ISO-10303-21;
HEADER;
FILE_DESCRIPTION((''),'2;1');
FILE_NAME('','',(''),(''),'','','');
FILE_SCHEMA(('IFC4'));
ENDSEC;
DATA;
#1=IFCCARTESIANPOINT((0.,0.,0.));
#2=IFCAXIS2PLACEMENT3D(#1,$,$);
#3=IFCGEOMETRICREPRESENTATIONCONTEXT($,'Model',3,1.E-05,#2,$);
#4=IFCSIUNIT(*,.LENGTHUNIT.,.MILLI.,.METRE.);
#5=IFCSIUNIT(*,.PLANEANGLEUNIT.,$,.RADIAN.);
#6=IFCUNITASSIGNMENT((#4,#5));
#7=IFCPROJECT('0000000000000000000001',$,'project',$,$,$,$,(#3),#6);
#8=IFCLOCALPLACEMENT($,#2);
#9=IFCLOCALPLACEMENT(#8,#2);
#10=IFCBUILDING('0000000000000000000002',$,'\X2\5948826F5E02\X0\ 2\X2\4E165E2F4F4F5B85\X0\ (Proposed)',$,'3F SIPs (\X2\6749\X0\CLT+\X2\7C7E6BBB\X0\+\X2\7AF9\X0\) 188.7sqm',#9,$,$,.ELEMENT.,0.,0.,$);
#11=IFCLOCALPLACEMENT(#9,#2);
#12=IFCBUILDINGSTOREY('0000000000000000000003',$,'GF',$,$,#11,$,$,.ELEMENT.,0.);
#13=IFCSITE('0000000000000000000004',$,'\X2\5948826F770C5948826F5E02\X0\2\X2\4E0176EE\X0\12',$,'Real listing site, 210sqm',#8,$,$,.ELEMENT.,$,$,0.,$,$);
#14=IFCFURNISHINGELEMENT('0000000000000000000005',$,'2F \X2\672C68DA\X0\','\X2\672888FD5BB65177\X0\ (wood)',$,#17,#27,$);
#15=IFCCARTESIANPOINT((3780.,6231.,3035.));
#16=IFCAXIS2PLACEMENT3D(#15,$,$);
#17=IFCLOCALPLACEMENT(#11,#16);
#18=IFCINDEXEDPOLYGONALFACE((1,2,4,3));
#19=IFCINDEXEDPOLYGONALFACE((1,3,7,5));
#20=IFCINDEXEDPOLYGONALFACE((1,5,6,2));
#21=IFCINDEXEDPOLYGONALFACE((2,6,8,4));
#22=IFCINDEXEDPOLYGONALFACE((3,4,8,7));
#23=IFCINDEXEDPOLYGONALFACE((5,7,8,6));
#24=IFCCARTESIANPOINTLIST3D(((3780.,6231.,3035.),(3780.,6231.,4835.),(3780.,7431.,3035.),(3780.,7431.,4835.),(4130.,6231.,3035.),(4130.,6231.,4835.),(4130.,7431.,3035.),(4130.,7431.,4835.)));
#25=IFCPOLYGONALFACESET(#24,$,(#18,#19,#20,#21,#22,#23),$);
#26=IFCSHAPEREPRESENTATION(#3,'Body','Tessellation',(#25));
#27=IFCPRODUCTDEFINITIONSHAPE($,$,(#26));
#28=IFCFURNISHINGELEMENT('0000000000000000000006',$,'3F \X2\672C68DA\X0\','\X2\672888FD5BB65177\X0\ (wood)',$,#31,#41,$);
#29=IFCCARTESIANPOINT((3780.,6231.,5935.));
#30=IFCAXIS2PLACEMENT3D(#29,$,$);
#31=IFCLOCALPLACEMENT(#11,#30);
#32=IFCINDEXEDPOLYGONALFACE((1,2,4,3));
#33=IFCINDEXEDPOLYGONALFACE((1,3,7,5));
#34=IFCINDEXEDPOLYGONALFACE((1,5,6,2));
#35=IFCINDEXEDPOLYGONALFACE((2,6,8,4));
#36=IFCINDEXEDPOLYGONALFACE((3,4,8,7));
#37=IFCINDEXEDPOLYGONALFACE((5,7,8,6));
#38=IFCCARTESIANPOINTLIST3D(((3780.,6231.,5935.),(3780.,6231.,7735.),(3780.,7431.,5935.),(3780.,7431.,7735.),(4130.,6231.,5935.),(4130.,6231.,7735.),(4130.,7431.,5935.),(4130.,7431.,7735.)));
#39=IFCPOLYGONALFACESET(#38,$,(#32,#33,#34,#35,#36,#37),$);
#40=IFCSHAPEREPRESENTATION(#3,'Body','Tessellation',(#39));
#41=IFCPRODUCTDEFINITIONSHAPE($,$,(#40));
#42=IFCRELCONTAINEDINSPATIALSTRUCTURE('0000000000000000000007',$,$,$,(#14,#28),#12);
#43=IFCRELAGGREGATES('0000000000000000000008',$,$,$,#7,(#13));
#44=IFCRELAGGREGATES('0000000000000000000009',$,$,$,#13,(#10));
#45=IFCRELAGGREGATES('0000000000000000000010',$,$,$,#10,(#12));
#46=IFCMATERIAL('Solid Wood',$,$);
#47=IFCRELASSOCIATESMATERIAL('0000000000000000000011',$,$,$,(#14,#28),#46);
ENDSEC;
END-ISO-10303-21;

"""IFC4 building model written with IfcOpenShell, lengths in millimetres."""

from ifc_helpers import new_model, si_unit, frame, frame_2d, origin, place, context, project, spatial, rectangle, extrude, material, element, save


model = new_model("IFC4")

# Units and contexts
model_context = context("Model", 3, precision=1e-05, world=origin())
ifc_project = project(units=[si_unit("LENGTHUNIT", "METRE", prefix="MILLI"), si_unit("PLANEANGLEUNIT", "RADIAN")], contexts=[model_context])

# Site, building, storey
site_placement = place(None, origin())
site = spatial("IfcSite", under=ifc_project, at=site_placement, Name="奈良県奈良市2丁目12", ObjectType="Real listing site, 210sqm", CompositionType="ELEMENT", RefElevation=0.0)
building_placement = place(site_placement, origin())
building = spatial("IfcBuilding", under=site, at=building_placement, Name="奈良市 2世帯住宅 (Proposed)", ObjectType="3F SIPs (杉CLT+籾殻+竹) 188.7sqm", CompositionType="ELEMENT", ElevationOfRefHeight=0.0, ElevationOfTerrain=0.0)
storey_placement = place(building_placement, origin())
storey = spatial("IfcBuildingStorey", under=building, at=storey_placement, Name="GF", CompositionType="ELEMENT", Elevation=0.0)

# Shared definitions
ifc_material_1 = material(Name="Solid Wood")

# Furnishing elements
furnishing_1_placement = place(storey_placement, frame((3780.0, 6231.0, 3035.0)))
element("IfcFurnishingElement", 1, at=furnishing_1_placement, inside=storey, material=ifc_material_1, Name="2F 本棚", Description="木製家具 (wood)", context=model_context, shape_type="SweptSolid", body=[
    extrude(rectangle(XDim=350.0, YDim=1200.0, at=frame_2d((175.0, 600.0))), frame((3780.0, 6231.0, 3035.0)), (0.0, 0.0, 1.0), 1800.0),
])
furnishing_2_placement = place(storey_placement, frame((3780.0, 6231.0, 5935.0)))
element("IfcFurnishingElement", 2, at=furnishing_2_placement, inside=storey, material=ifc_material_1, Name="3F 本棚", Description="木製家具 (wood)", context=model_context, shape_type="SweptSolid", body=[
    extrude(rectangle(XDim=350.0, YDim=1200.0, at=frame_2d((175.0, 600.0))), frame((3780.0, 6231.0, 5935.0)), (0.0, 0.0, 1.0), 1800.0),
])

save(model, "model.ifc")
